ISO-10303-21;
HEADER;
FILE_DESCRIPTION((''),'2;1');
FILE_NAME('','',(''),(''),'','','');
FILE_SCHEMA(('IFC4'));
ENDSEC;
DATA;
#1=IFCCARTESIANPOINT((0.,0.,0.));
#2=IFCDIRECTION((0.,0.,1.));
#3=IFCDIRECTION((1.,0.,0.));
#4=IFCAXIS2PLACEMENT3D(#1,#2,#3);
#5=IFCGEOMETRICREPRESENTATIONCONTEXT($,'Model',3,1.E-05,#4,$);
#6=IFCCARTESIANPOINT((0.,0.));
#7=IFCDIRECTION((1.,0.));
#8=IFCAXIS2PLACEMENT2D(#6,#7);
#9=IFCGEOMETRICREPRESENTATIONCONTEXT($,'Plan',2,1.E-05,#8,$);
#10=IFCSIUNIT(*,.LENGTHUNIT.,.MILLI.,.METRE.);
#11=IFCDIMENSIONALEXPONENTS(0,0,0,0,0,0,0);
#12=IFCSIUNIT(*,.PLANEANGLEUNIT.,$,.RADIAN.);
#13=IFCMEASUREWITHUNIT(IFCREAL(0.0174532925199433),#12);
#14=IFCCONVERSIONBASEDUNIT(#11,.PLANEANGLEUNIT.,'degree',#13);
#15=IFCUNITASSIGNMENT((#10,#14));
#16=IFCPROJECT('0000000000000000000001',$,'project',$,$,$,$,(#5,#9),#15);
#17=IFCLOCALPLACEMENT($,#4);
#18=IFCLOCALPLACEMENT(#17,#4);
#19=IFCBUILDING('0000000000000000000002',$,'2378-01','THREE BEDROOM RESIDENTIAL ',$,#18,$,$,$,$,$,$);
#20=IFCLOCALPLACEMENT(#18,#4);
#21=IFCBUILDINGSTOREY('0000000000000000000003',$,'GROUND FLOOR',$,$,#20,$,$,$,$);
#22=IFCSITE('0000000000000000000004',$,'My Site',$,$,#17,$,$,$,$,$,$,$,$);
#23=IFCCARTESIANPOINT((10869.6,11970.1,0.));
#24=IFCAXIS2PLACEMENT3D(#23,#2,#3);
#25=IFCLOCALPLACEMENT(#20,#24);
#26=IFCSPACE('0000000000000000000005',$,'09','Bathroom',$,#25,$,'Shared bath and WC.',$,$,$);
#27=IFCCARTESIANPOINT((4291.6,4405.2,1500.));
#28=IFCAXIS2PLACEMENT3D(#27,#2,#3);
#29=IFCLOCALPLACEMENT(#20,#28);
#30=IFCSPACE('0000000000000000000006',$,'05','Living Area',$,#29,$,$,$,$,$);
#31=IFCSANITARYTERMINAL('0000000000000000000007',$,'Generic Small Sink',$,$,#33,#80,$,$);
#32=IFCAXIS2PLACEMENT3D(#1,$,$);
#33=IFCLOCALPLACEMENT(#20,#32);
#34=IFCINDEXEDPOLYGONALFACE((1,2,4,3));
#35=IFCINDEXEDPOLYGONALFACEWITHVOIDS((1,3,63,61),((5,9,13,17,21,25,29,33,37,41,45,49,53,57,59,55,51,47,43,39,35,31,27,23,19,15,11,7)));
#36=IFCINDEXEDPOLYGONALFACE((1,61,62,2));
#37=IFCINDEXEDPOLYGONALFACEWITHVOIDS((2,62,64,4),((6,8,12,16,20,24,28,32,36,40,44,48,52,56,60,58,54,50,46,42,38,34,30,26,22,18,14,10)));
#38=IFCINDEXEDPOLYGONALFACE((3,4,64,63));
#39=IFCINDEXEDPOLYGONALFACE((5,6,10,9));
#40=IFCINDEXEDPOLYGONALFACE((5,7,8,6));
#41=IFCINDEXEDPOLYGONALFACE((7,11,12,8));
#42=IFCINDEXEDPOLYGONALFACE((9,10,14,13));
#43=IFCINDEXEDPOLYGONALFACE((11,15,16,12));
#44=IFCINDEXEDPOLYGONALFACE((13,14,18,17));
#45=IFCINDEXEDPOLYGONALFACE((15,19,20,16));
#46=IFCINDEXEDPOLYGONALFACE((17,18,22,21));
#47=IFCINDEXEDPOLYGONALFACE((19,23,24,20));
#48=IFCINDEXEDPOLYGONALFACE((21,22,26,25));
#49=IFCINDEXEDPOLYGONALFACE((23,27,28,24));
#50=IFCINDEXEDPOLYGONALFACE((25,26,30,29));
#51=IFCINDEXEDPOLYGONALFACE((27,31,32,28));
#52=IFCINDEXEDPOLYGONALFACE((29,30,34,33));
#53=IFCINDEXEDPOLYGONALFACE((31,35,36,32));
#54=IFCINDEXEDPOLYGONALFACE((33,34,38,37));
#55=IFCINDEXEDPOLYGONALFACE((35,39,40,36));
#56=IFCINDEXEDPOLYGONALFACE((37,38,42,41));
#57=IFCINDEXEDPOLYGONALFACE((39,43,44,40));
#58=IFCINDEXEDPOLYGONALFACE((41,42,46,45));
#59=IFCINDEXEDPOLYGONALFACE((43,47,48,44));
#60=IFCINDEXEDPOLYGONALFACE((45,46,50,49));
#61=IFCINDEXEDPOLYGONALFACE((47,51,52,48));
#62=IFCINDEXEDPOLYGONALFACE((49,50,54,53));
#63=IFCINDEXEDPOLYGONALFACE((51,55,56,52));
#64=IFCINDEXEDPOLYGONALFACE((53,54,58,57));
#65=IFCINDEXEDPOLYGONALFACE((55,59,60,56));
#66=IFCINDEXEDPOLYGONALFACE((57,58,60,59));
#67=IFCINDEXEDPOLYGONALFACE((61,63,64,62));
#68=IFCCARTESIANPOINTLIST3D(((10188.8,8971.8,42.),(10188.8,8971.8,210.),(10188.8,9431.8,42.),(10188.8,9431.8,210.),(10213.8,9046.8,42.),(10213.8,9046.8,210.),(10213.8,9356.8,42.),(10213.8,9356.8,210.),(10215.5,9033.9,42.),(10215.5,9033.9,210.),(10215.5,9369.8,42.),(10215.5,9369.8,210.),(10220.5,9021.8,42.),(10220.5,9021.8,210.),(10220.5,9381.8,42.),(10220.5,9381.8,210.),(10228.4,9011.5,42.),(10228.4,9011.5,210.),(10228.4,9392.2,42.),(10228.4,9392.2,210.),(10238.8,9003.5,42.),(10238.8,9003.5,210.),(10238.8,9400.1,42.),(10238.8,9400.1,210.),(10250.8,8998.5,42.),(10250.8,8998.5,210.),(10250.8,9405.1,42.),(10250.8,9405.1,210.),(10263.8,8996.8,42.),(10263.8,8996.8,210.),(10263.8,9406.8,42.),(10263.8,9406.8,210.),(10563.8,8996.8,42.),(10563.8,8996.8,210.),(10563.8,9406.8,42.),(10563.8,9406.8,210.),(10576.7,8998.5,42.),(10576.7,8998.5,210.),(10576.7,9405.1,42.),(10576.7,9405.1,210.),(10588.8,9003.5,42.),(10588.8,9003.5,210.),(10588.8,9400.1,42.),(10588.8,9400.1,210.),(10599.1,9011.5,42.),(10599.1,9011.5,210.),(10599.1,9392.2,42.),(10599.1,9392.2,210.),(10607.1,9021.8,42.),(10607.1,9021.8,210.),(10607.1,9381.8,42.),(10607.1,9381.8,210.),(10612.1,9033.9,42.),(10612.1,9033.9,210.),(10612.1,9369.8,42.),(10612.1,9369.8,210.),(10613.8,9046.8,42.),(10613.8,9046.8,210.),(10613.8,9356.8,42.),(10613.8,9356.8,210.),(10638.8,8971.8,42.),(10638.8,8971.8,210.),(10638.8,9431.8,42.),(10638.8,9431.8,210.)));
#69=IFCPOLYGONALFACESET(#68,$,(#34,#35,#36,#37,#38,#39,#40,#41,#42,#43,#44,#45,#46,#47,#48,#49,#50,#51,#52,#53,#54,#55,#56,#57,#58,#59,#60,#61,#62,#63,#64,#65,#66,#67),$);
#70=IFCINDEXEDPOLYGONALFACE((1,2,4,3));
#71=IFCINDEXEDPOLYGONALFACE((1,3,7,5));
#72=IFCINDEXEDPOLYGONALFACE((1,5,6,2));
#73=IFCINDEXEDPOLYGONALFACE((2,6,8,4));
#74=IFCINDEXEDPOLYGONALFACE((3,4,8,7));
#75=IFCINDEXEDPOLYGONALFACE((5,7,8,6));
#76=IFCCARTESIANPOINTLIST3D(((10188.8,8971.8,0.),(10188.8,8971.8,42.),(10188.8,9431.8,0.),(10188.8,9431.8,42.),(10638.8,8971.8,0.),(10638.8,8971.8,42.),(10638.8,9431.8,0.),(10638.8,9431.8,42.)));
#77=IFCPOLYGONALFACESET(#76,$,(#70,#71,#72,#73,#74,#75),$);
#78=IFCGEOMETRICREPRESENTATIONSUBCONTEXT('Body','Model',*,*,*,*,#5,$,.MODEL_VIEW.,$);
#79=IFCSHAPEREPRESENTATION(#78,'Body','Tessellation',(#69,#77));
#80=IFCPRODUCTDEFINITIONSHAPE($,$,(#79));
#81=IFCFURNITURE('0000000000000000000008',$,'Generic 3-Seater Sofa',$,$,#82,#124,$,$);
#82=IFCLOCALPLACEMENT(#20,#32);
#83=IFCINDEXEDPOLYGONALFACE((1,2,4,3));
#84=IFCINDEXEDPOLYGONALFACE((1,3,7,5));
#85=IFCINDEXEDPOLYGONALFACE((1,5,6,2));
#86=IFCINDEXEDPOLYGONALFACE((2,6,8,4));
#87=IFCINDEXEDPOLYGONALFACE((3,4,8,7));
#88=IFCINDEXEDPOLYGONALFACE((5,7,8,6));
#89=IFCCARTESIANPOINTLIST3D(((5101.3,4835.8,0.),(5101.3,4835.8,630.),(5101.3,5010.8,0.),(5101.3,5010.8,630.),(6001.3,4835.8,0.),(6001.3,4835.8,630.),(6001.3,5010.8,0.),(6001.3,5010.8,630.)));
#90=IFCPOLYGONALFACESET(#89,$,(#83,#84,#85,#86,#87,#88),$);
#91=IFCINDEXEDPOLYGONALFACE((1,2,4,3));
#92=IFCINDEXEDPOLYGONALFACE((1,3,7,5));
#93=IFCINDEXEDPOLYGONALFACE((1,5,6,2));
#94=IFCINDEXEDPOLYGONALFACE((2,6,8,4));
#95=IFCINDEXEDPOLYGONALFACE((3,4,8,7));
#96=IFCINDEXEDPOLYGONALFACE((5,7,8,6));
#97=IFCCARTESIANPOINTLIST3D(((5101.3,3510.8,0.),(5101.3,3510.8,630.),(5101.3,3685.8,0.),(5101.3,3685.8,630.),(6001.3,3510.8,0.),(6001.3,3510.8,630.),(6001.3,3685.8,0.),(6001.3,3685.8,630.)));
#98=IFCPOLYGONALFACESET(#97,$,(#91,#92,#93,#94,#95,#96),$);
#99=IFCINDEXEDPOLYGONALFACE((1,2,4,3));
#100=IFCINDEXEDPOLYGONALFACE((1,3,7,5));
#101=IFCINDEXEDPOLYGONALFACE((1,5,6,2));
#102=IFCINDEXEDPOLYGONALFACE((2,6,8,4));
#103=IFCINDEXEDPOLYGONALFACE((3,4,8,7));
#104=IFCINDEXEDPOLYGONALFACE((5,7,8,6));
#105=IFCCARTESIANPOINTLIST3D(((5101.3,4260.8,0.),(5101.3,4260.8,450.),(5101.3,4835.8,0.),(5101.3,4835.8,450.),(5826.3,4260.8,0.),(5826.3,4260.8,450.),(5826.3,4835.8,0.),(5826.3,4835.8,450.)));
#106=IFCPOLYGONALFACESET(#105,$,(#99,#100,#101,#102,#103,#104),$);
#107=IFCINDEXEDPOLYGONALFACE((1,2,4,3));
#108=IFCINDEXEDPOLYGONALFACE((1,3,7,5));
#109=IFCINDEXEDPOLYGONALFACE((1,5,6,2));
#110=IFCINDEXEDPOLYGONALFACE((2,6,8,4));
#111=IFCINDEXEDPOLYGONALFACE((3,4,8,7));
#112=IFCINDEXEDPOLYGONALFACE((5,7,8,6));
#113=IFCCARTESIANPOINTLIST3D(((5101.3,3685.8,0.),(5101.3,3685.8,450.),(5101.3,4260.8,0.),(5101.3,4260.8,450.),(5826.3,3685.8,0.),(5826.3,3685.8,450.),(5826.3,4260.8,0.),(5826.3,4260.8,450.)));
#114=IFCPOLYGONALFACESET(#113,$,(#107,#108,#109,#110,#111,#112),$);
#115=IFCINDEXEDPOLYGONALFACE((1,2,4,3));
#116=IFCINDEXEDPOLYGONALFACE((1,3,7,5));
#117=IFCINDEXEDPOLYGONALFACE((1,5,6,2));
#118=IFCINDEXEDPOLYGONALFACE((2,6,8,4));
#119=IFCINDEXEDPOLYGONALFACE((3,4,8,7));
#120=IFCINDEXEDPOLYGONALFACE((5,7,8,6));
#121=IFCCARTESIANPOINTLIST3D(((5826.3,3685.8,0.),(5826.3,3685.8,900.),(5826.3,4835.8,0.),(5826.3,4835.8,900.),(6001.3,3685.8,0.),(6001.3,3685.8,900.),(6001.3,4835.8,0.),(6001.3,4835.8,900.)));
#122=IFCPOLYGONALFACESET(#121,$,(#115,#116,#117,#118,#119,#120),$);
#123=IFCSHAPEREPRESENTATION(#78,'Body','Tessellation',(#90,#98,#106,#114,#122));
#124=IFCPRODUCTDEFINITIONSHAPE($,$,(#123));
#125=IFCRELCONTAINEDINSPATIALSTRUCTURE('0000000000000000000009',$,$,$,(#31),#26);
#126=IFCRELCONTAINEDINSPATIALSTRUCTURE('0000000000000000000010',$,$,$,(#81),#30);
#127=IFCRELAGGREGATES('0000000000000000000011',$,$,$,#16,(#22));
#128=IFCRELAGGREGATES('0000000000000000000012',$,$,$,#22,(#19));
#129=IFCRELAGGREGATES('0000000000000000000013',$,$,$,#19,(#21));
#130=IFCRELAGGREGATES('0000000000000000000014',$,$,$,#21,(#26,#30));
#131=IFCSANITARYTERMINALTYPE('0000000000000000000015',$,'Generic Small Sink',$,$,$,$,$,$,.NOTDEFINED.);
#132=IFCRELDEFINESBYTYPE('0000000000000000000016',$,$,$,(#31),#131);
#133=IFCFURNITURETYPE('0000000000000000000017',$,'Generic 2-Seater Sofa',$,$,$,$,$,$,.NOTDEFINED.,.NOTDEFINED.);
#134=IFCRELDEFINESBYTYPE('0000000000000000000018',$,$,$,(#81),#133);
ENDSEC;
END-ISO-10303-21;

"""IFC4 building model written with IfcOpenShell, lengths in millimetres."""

from ifc_helpers import new_model, entity, si_unit, converted_unit, frame, origin_with_axes, origin_2d_with_axis, place, context, subcontext, project, spatial, line, indexed_curve, outline, extrude, shape, source, transform, mapped, type_object, type_shapes, element, save


model = new_model("IFC4")

# Units and contexts
model_context = context("Model", 3, precision=1e-05, world=origin_with_axes())
plan_context = context("Plan", 2, precision=1e-05, world=origin_2d_with_axis())
body_context_1 = subcontext(model_context, "Body", "Model", "MODEL_VIEW")
body_context_2 = subcontext(plan_context, "Body", "Plan", "PLAN_VIEW")
ifc_project = project(units=[si_unit("LENGTHUNIT", "METRE", prefix="MILLI"), converted_unit("PLANEANGLEUNIT", "degree", entity("IfcReal", 0.0174532925199433), si_unit("PLANEANGLEUNIT", "RADIAN"), dimensions=[0, 0, 0, 0, 0, 0, 0])], contexts=[model_context, plan_context])

# Site, building, storey
site_placement = place(None, origin_with_axes())
site = spatial("IfcSite", under=ifc_project, at=site_placement, Name="My Site")
building_placement = place(site_placement, origin_with_axes())
building = spatial("IfcBuilding", under=site, at=building_placement, Name="2378-01", Description="THREE BEDROOM RESIDENTIAL ")
storey_placement = place(building_placement, origin_with_axes())
storey = spatial("IfcBuildingStorey", under=building, at=storey_placement, Name="GROUND FLOOR")

# Shared definitions
space_1_placement = place(storey_placement, frame((10869.6, 11970.1, 0.0), z_axis=(0.0, 0.0, 1.0), x_axis=(1.0, 0.0, 0.0)))
space_1 = spatial("IfcSpace", under=storey, at=space_1_placement, Name="09", Description="Bathroom", LongName="Shared bath and WC.")

# Sanitary terminal
sanitary_terminal_type_1 = type_object("IfcSanitaryTerminalType", Name="Generic Small Sink", PredefinedType="NOTDEFINED")
shared_indexed_poly_curve = entity("IfcIndexedPolyCurve", entity("IfcCartesianPointList2D", [[0.0, 0.0], [450.0, 0.0], [450.0, 460.0], [0.0, 460.0]]), [entity("IfcLineIndex", [1, 2, 3, 4, 1])])
shared_shape_1 = source(origin_with_axes(), body_context_1, "Body", "SweptSolid", [
    entity("IfcExtrudedAreaSolid", entity("IfcArbitraryProfileDefWithVoids", "AREA", None, shared_indexed_poly_curve, [entity("IfcIndexedPolyCurve", entity("IfcCartesianPointList2D", [[25.0, 75.0], [39.6, 39.6], [75.0, 25.0], [375.0, 25.0], [410.4, 39.6], [425.0, 75.0], [425.0, 385.0], [410.4, 420.4], [375.0, 435.0], [75.0, 435.0], [39.6, 420.4], [25.0, 385.0]]), [entity("IfcLineIndex", [12, 1]), entity("IfcArcIndex", [1, 2, 3]), entity("IfcLineIndex", [3, 4]), entity("IfcArcIndex", [4, 5, 6]), entity("IfcLineIndex", [6, 7]), entity("IfcArcIndex", [7, 8, 9]), entity("IfcLineIndex", [9, 10]), entity("IfcArcIndex", [10, 11, 12]), entity("IfcLineIndex", [12, 1])])]), entity("IfcAxis2Placement3D", entity("IfcCartesianPoint", [-225.0, -460.0, 42.0]), entity("IfcDirection", [0.0, 0.0, 1.0]), entity("IfcDirection", [1.0, 0.0, 0.0])), entity("IfcDirection", [0.0, 0.0, 1.0]), 168.0),
    entity("IfcExtrudedAreaSolid", entity("IfcArbitraryClosedProfileDef", "AREA", None, shared_indexed_poly_curve), entity("IfcAxis2Placement3D", entity("IfcCartesianPoint", [-225.0, -460.0, 0.0]), entity("IfcDirection", [0.0, 0.0, 1.0]), entity("IfcDirection", [1.0, 0.0, 0.0])), entity("IfcDirection", [0.0, 0.0, 1.0]), 42.0),
])
shared_shape_2 = source(origin_with_axes(), body_context_2, "Body", "Curve2D", [
    entity("IfcIndexedPolyCurve", entity("IfcCartesianPointList2D", [[-225.0, -460.0], [225.0, -460.0], [225.0, 0.0], [-225.0, 0.0]]), [entity("IfcLineIndex", [1, 2, 3, 4, 1])]),
    entity("IfcIndexedPolyCurve", entity("IfcCartesianPointList2D", [[-200.0, -385.0], [-185.4, -420.4], [-150.0, -435.0], [150.0, -435.0], [185.4, -420.4], [200.0, -385.0], [200.0, -75.0], [185.4, -39.6], [150.0, -25.0], [-150.0, -25.0], [-185.4, -39.6], [-200.0, -75.0]]), [entity("IfcLineIndex", [12, 1]), entity("IfcArcIndex", [1, 2, 3]), entity("IfcLineIndex", [3, 4]), entity("IfcArcIndex", [4, 5, 6]), entity("IfcLineIndex", [6, 7]), entity("IfcArcIndex", [7, 8, 9]), entity("IfcLineIndex", [9, 10]), entity("IfcArcIndex", [10, 11, 12]), entity("IfcLineIndex", [12, 1])]),
    entity("IfcCircle", entity("IfcAxis2Placement2D", entity("IfcCartesianPoint", [0.0, -125.0])), 25.0),
    entity("IfcIndexedPolyCurve", entity("IfcCartesianPointList2D", [[0.0, -12.5], [0.0, -132.5]])),
])
type_shapes(sanitary_terminal_type_1, [shared_shape_1, shared_shape_2])
sanitary_terminal_1_placement = place(space_1_placement, frame((-455.8, -2998.3, 0.0), z_axis=(0.0, 0.0, 1.0), x_axis=(-1.0, 0.0, 0.0)))
element("IfcSanitaryTerminal", 1, at=sanitary_terminal_1_placement, inside=space_1, type_object=sanitary_terminal_type_1, Name="Generic Small Sink", shapes=[
    shape(body_context_1, "Body", "MappedRepresentation", [mapped(shared_shape_1, transform((0.0, 0.0, 0.0), x_axis=(1.0, 0.0, 0.0), y_axis=(0.0, 1.0, 0.0), z_axis=(0.0, 0.0, 1.0), scale=1.0))]),
    shape(body_context_2, "Body", "MappedRepresentation", [mapped(shared_shape_2, transform((0.0, 0.0, 0.0), x_axis=(1.0, 0.0, 0.0), y_axis=(0.0, 1.0, 0.0), z_axis=(0.0, 0.0, 1.0), scale=1.0))]),
])

# Shared definitions
space_2_placement = place(storey_placement, frame((4291.6, 4405.2, 1500.0), z_axis=(0.0, 0.0, 1.0), x_axis=(1.0, 0.0, 0.0)))
space_2 = spatial("IfcSpace", under=storey, at=space_2_placement, Name="05", Description="Living Area")

# Furniture
furniture_type_1 = type_object("IfcFurnitureType", Name="Generic 2-Seater Sofa", AssemblyPlace="NOTDEFINED", PredefinedType="NOTDEFINED")
shared_shape_3 = source(origin_with_axes(), body_context_1, "Body", "SweptSolid", [
    extrude(outline(indexed_curve([(0.0, 0.0), (175.0, 0.0), (175.0, 900.0), (0.0, 900.0)], segments=[line(1, 2, 3, 4, 1)])), frame((-750.0, -900.0, 0.0), z_axis=(0.0, 0.0, 1.0), x_axis=(1.0, 0.0, 0.0)), (0.0, 0.0, 1.0), 630.0),
    extrude(outline(indexed_curve([(0.0, 0.0), (175.0, 0.0), (175.0, 900.0), (0.0, 900.0)], segments=[line(1, 2, 3, 4, 1)])), frame((575.0, -900.0, 0.0), z_axis=(0.0, 0.0, 1.0), x_axis=(1.0, 0.0, 0.0)), (0.0, 0.0, 1.0), 630.0),
    extrude(outline(indexed_curve([(175.0, 0.0), (750.0, 0.0), (750.0, 725.0), (175.0, 725.0)], segments=[line(1, 2, 3, 4, 1)])), frame((-750.0, -900.0, 0.0), z_axis=(0.0, 0.0, 1.0), x_axis=(1.0, 0.0, 0.0)), (0.0, 0.0, 1.0), 450.0),
    extrude(outline(indexed_curve([(750.0, 0.0), (1325.0, 0.0), (1325.0, 725.0), (750.0, 725.0)], segments=[line(1, 2, 3, 4, 1)])), frame((-750.0, -900.0, 0.0), z_axis=(0.0, 0.0, 1.0), x_axis=(1.0, 0.0, 0.0)), (0.0, 0.0, 1.0), 450.0),
    extrude(outline(indexed_curve([(175.0, 725.0), (1325.0, 725.0), (1325.0, 900.0), (175.0, 900.0)], segments=[line(1, 2, 3, 4, 1)])), frame((-750.0, -900.0, 0.0), z_axis=(0.0, 0.0, 1.0), x_axis=(1.0, 0.0, 0.0)), (0.0, 0.0, 1.0), 900.0),
])
shared_shape_4 = source(origin_with_axes(), body_context_2, "Body", "Curve2D", [
    entity("IfcIndexedPolyCurve", entity("IfcCartesianPointList2D", [[-750.0, -900.0], [-575.0, -900.0], [-575.0, 0.0], [-750.0, 0.0]]), [entity("IfcLineIndex", [1, 2, 3, 4, 1])]),
    entity("IfcIndexedPolyCurve", entity("IfcCartesianPointList2D", [[575.0, -900.0], [750.0, -900.0], [750.0, 0.0], [575.0, 0.0]]), [entity("IfcLineIndex", [1, 2, 3, 4, 1])]),
    entity("IfcIndexedPolyCurve", entity("IfcCartesianPointList2D", [[-575.0, -900.0], [0.0, -900.0], [0.0, -175.0], [-575.0, -175.0]]), [entity("IfcLineIndex", [1, 2, 3, 4, 1])]),
    entity("IfcIndexedPolyCurve", entity("IfcCartesianPointList2D", [[0.0, -900.0], [575.0, -900.0], [575.0, -175.0], [0.0, -175.0]]), [entity("IfcLineIndex", [1, 2, 3, 4, 1])]),
    entity("IfcIndexedPolyCurve", entity("IfcCartesianPointList2D", [[-575.0, -175.0], [575.0, -175.0], [575.0, 0.0], [-575.0, 0.0]]), [entity("IfcLineIndex", [1, 2, 3, 4, 1])]),
])
type_shapes(furniture_type_1, [shared_shape_3, shared_shape_4])
furniture_1_placement = place(space_2_placement, frame((1709.7, -144.4, -1500.0), z_axis=(0.0, 0.0, 1.0), x_axis=(0.0, -1.0, 0.0)))
element("IfcFurniture", 2, at=furniture_1_placement, inside=space_2, type_object=furniture_type_1, Name="Generic 3-Seater Sofa", shapes=[
    shape(body_context_1, "Body", "MappedRepresentation", [mapped(shared_shape_3, transform((0.0, 0.0, 0.0), x_axis=(1.0, 0.0, 0.0), y_axis=(0.0, 1.0, 0.0), z_axis=(0.0, 0.0, 1.0), scale=1.0))]),
    shape(body_context_2, "Body", "MappedRepresentation", [mapped(shared_shape_4, transform((0.0, 0.0, 0.0), x_axis=(1.0, 0.0, 0.0), y_axis=(0.0, 1.0, 0.0), z_axis=(0.0, 0.0, 1.0), scale=1.0))]),
])

save(model, "model.ifc")
